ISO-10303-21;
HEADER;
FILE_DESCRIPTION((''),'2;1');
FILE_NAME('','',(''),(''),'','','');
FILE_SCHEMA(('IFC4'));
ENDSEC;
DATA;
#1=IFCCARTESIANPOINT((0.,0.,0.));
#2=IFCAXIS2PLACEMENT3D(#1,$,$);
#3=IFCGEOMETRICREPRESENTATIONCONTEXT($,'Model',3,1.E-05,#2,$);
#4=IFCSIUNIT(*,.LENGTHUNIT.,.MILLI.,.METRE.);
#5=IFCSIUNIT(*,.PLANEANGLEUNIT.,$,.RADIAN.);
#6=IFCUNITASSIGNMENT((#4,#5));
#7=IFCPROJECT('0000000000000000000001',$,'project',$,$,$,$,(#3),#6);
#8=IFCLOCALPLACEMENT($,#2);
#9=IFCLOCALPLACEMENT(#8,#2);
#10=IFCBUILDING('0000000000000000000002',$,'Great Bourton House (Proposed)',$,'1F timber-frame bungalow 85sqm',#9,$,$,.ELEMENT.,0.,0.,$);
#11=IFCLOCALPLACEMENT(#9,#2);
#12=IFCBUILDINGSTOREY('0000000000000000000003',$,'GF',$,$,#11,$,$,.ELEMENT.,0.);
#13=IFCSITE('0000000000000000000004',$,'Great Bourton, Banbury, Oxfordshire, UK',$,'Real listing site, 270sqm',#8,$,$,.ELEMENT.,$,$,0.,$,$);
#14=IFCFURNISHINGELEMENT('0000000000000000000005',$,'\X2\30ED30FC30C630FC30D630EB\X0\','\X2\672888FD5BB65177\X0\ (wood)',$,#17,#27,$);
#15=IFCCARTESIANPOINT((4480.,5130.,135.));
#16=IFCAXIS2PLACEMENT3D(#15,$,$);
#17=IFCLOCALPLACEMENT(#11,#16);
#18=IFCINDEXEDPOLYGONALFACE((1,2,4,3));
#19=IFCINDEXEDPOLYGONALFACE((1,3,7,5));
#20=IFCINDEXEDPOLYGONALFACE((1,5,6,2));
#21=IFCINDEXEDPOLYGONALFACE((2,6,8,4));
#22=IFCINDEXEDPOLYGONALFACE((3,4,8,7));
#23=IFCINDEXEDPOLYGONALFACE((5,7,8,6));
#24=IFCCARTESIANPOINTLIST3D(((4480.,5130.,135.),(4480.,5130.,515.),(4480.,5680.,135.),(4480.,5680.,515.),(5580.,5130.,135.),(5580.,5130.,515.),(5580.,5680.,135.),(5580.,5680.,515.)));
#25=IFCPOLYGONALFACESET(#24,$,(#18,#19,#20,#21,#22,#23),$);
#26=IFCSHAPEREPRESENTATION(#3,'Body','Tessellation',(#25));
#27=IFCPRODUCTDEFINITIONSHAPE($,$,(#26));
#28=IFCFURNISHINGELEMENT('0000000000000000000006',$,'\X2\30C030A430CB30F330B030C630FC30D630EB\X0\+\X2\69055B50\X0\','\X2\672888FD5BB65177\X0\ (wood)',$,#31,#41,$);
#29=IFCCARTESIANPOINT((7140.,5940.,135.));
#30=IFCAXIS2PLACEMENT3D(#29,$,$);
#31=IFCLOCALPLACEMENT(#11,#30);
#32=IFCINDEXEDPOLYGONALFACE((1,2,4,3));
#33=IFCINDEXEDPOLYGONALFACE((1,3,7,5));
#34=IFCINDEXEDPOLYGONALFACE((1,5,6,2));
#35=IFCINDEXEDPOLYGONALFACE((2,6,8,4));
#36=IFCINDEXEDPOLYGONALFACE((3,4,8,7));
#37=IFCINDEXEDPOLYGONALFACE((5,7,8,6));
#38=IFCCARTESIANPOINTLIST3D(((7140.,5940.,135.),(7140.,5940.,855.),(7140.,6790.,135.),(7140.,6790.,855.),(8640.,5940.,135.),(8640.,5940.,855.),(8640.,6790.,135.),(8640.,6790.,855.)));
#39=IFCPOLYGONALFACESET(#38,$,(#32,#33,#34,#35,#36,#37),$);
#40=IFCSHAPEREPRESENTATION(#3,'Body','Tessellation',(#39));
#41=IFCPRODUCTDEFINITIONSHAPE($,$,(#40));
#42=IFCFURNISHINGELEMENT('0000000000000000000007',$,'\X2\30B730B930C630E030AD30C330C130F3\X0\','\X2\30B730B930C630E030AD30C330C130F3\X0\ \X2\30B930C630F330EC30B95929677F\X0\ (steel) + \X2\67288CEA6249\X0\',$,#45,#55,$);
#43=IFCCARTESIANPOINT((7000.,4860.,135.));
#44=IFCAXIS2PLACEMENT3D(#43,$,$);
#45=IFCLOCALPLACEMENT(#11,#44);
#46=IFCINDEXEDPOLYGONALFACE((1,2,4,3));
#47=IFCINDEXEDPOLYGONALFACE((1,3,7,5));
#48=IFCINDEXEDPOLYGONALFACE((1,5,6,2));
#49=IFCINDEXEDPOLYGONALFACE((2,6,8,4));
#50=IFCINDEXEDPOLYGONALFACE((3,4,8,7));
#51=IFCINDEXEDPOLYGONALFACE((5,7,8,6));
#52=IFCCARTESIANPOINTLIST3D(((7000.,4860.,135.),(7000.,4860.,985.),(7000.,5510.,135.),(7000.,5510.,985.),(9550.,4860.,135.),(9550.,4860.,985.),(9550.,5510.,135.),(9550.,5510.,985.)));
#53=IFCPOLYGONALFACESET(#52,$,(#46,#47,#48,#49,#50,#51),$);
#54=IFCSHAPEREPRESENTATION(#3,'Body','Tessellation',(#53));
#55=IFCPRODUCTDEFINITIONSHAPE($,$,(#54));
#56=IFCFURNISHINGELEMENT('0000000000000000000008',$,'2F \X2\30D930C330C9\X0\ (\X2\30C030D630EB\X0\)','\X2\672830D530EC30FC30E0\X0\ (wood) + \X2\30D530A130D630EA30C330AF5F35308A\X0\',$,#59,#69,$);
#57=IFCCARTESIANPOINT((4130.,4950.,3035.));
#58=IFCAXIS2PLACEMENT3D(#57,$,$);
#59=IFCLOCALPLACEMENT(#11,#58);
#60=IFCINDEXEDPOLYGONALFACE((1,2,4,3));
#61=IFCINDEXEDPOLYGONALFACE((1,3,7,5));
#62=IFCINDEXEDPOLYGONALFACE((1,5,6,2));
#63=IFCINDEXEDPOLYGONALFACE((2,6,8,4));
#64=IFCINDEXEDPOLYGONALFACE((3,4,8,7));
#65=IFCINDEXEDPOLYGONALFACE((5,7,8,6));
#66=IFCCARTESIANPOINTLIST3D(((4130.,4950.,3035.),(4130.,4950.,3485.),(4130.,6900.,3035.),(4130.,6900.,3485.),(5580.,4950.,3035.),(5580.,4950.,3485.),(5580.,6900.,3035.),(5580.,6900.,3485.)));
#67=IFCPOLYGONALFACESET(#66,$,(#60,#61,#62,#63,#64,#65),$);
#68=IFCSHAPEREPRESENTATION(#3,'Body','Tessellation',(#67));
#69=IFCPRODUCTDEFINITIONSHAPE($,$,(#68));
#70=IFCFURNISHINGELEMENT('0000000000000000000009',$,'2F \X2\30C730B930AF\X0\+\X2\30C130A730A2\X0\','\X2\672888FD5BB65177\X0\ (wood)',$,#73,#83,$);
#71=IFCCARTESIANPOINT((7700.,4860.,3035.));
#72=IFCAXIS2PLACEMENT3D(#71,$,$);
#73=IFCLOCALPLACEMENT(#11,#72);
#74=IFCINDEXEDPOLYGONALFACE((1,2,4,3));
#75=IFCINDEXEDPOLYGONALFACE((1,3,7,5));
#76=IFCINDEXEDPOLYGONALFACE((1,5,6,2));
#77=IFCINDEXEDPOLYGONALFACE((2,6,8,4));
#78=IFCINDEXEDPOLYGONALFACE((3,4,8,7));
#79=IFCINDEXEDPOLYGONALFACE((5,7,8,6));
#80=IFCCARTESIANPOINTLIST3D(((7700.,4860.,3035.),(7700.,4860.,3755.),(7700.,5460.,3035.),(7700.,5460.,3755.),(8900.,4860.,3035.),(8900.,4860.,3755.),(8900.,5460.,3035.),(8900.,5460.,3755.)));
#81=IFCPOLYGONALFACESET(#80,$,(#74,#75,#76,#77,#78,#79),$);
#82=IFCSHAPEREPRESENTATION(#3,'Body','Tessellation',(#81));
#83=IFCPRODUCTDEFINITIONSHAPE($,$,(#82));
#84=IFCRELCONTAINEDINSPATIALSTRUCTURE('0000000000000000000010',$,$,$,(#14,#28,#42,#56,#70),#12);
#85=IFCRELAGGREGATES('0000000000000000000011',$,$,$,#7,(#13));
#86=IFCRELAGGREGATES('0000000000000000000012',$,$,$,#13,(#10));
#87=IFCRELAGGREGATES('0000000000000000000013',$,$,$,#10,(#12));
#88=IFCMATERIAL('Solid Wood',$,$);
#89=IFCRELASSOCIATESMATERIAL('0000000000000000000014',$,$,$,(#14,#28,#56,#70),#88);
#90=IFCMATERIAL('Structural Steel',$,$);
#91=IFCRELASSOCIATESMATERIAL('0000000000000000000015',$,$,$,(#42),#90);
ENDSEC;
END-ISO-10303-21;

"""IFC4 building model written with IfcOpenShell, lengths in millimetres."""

from ifc_helpers import new_model, si_unit, frame, frame_2d, origin, place, context, project, spatial, rectangle, extrude, material, element, save


model = new_model("IFC4")

# Units and contexts
model_context = context("Model", 3, precision=1e-05, world=origin())
ifc_project = project(units=[si_unit("LENGTHUNIT", "METRE", prefix="MILLI"), si_unit("PLANEANGLEUNIT", "RADIAN")], contexts=[model_context])

# Site, building, storey
site_placement = place(None, origin())
site = spatial("IfcSite", under=ifc_project, at=site_placement, Name="Great Bourton, Banbury, Oxfordshire, UK", ObjectType="Real listing site, 270sqm", CompositionType="ELEMENT", RefElevation=0.0)
building_placement = place(site_placement, origin())
building = spatial("IfcBuilding", under=site, at=building_placement, Name="Great Bourton House (Proposed)", ObjectType="1F timber-frame bungalow 85sqm", CompositionType="ELEMENT", ElevationOfRefHeight=0.0, ElevationOfTerrain=0.0)
storey_placement = place(building_placement, origin())
storey = spatial("IfcBuildingStorey", under=building, at=storey_placement, Name="GF", CompositionType="ELEMENT", Elevation=0.0)

# Shared definitions
ifc_material_1 = material(Name="Solid Wood")

# Shared definitions
ifc_material_2 = material(Name="Structural Steel")

# Furnishing elements
furnishing_1_placement = place(storey_placement, frame((4480.0, 5130.0, 135.0)))
element("IfcFurnishingElement", 1, at=furnishing_1_placement, inside=storey, material=ifc_material_1, Name="ローテーブル", Description="木製家具 (wood)", context=model_context, shape_type="SweptSolid", body=[
    extrude(rectangle(XDim=1100.0, YDim=550.0, at=frame_2d((550.0, 275.0))), frame((4480.0, 5130.0, 135.0)), (0.0, 0.0, 1.0), 380.0),
])
furnishing_2_placement = place(storey_placement, frame((7140.0, 5940.0, 135.0)))
element("IfcFurnishingElement", 2, at=furnishing_2_placement, inside=storey, material=ifc_material_1, Name="ダイニングテーブル+椅子", Description="木製家具 (wood)", context=model_context, shape_type="SweptSolid", body=[
    extrude(rectangle(XDim=1500.0, YDim=850.0, at=frame_2d((750.0, 425.0))), frame((7140.0, 5940.0, 135.0)), (0.0, 0.0, 1.0), 720.0),
])
furnishing_3_placement = place(storey_placement, frame((7000.0, 4860.0, 135.0)))
element("IfcFurnishingElement", 3, at=furnishing_3_placement, inside=storey, material=ifc_material_2, Name="システムキッチン", Description="システムキッチン ステンレス天板 (steel) + 木質扉", context=model_context, shape_type="SweptSolid", body=[
    extrude(rectangle(XDim=2550.0, YDim=650.0, at=frame_2d((1275.0, 325.0))), frame((7000.0, 4860.0, 135.0)), (0.0, 0.0, 1.0), 850.0),
])
furnishing_4_placement = place(storey_placement, frame((4130.0, 4950.0, 3035.0)))
element("IfcFurnishingElement", 4, at=furnishing_4_placement, inside=storey, material=ifc_material_1, Name="2F ベッド (ダブル)", Description="木フレーム (wood) + ファブリック張り", context=model_context, shape_type="SweptSolid", body=[
    extrude(rectangle(XDim=1450.0, YDim=1950.0, at=frame_2d((725.0, 975.0))), frame((4130.0, 4950.0, 3035.0)), (0.0, 0.0, 1.0), 450.0),
])
furnishing_5_placement = place(storey_placement, frame((7700.0, 4860.0, 3035.0)))
element("IfcFurnishingElement", 5, at=furnishing_5_placement, inside=storey, material=ifc_material_1, Name="2F デスク+チェア", Description="木製家具 (wood)", context=model_context, shape_type="SweptSolid", body=[
    extrude(rectangle(XDim=1200.0, YDim=600.0, at=frame_2d((600.0, 300.0))), frame((7700.0, 4860.0, 3035.0)), (0.0, 0.0, 1.0), 720.0),
])

save(model, "model.ifc")
